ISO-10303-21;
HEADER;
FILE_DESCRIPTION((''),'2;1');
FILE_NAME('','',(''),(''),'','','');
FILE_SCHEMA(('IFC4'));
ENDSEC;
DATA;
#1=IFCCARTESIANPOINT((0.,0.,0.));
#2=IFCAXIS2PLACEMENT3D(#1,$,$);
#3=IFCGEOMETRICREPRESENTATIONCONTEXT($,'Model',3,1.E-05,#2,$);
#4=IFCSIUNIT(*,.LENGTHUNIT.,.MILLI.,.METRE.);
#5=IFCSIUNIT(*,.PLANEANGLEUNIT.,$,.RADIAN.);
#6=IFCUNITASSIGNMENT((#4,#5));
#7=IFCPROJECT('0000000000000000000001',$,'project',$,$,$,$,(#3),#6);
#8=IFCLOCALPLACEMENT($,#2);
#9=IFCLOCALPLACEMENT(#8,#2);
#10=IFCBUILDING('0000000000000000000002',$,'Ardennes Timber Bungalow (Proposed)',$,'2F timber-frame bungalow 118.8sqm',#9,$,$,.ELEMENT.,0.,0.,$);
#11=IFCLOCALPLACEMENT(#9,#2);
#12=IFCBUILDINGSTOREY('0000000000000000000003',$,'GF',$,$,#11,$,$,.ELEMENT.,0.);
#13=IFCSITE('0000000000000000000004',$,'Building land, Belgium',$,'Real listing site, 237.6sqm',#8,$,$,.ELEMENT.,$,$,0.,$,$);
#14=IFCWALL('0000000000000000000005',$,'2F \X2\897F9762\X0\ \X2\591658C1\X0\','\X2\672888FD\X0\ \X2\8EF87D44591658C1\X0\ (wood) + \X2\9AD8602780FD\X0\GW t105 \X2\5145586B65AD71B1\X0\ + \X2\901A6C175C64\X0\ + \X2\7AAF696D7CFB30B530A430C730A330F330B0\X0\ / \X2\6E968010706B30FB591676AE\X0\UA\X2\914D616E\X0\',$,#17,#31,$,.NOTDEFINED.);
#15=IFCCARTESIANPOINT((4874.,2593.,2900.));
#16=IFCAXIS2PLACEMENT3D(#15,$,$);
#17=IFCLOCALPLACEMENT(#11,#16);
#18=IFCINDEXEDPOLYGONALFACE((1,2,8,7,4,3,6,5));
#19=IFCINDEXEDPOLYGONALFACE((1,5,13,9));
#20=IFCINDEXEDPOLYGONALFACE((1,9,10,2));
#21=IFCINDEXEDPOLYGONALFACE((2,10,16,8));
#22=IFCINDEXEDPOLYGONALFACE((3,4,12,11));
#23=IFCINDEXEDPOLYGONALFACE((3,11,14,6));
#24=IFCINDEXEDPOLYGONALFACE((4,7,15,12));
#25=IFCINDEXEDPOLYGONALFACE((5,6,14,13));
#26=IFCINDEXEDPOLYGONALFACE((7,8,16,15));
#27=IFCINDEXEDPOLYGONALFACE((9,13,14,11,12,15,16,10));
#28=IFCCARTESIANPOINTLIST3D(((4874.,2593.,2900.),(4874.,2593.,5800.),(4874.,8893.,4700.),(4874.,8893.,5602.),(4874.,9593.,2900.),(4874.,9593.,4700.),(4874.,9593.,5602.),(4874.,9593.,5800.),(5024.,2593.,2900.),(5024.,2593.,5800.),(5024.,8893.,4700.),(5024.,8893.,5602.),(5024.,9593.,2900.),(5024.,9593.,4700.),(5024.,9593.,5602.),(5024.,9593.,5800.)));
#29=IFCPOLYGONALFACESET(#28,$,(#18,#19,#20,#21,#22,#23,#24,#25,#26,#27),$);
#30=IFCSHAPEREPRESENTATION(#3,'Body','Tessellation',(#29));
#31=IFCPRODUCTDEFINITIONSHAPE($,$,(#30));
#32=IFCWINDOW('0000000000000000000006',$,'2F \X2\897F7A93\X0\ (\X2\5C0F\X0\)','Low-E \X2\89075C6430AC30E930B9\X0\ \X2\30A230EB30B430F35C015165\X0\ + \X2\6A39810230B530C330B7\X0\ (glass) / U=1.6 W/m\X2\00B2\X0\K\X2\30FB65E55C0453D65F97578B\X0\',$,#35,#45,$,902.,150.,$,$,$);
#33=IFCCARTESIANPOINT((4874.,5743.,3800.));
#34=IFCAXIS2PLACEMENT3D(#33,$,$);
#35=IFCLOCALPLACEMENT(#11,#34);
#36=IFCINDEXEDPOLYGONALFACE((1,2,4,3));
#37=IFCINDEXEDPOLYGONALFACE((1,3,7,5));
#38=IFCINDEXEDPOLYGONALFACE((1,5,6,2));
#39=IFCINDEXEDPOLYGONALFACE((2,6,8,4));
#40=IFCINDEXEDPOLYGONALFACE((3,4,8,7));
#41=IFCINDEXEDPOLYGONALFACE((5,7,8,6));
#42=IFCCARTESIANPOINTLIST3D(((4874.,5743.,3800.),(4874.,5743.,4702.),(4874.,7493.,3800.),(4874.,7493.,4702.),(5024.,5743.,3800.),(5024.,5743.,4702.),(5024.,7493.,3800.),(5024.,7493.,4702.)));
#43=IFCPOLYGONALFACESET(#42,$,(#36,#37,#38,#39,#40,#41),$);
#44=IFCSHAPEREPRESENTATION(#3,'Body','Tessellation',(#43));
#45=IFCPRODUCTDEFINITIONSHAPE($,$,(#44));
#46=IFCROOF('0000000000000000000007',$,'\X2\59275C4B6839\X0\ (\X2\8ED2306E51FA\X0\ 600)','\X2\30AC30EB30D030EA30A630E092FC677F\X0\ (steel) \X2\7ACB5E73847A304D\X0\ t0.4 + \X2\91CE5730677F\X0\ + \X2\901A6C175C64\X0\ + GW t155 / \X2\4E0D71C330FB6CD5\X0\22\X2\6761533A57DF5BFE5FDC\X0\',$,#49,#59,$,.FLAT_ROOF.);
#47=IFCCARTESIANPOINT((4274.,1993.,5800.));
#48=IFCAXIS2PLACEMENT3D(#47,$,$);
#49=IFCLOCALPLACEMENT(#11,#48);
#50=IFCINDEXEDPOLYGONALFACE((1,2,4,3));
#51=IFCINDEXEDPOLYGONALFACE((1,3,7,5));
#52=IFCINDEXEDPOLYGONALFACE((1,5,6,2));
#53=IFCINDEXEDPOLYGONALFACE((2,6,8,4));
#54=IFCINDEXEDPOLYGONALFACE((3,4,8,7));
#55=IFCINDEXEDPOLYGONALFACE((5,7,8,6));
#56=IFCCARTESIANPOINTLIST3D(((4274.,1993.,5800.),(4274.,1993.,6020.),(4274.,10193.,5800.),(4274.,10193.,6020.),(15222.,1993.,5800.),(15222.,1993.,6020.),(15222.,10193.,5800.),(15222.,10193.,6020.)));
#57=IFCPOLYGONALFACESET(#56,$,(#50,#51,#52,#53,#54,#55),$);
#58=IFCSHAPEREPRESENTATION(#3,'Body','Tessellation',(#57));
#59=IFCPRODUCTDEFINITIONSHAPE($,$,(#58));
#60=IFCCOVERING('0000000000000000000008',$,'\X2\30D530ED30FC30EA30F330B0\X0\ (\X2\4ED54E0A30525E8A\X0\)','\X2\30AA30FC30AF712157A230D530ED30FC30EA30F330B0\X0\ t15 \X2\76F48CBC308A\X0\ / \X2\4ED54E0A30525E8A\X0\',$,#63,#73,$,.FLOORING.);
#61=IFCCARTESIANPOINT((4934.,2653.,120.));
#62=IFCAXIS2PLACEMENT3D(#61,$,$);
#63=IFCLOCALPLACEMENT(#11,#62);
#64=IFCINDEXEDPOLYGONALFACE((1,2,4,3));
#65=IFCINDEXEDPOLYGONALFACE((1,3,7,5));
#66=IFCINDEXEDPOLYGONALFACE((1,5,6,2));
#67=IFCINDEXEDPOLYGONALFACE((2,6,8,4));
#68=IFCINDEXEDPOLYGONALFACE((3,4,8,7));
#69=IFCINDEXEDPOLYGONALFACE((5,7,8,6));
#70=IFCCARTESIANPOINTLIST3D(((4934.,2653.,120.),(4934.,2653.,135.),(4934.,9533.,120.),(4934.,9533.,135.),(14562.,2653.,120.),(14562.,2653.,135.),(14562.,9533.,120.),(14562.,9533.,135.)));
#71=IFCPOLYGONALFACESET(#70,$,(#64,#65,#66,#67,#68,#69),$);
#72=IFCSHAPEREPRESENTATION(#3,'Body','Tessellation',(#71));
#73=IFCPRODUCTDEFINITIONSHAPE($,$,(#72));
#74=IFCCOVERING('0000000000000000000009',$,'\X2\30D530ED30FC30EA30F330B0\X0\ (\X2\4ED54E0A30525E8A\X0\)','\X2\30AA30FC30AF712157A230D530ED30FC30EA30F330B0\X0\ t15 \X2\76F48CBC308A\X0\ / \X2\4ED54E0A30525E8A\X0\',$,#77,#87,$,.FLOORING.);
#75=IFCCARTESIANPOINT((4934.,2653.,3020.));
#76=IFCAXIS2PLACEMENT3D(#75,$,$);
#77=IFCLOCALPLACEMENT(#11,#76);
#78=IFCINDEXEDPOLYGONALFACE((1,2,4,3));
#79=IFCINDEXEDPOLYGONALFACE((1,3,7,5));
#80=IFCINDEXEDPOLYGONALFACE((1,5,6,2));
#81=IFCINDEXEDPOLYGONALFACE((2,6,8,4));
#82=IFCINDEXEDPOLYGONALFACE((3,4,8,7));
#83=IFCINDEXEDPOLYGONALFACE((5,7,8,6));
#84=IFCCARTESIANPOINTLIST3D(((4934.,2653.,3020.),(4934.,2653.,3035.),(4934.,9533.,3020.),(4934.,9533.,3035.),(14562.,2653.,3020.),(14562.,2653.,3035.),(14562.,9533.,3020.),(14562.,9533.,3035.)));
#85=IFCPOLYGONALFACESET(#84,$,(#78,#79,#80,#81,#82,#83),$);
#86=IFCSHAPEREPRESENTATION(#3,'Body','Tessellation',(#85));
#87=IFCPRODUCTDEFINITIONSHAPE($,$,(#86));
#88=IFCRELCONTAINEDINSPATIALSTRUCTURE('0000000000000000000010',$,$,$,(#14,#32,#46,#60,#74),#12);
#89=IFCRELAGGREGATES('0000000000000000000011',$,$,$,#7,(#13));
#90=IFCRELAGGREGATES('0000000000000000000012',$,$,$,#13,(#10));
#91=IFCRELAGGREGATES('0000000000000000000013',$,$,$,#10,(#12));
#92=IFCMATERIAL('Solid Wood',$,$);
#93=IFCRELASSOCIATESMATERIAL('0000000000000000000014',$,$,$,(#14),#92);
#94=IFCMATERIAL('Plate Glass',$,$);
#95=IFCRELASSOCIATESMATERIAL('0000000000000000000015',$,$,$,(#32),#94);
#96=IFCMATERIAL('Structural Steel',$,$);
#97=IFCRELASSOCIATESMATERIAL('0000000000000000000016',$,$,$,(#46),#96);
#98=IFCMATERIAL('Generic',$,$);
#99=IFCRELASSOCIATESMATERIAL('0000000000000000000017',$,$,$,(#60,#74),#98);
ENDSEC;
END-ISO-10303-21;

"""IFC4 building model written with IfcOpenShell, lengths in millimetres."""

from ifc_helpers import new_model, si_unit, frame, frame_2d, origin, place, context, project, spatial, rectangle, extrude, material, element, fill, save


model = new_model("IFC4")

# Units and contexts
model_context = context("Model", 3, precision=1e-05, world=origin())
ifc_project = project(units=[si_unit("LENGTHUNIT", "METRE", prefix="MILLI"), si_unit("PLANEANGLEUNIT", "RADIAN")], contexts=[model_context])

# Site, building, storey
site_placement = place(None, origin())
site = spatial("IfcSite", under=ifc_project, at=site_placement, Name="Building land, Belgium", ObjectType="Real listing site, 237.6sqm", CompositionType="ELEMENT", RefElevation=0.0)
building_placement = place(site_placement, origin())
building = spatial("IfcBuilding", under=site, at=building_placement, Name="Ardennes Timber Bungalow (Proposed)", ObjectType="2F timber-frame bungalow 118.8sqm", CompositionType="ELEMENT", ElevationOfRefHeight=0.0, ElevationOfTerrain=0.0)
storey_placement = place(building_placement, origin())
storey = spatial("IfcBuildingStorey", under=building, at=storey_placement, Name="GF", CompositionType="ELEMENT", Elevation=0.0)

# Shared definitions
ifc_material_1 = material(Name="Solid Wood")

# Shared definitions
ifc_material_2 = material(Name="Plate Glass")

# Wall, opening, window
wall_1_placement = place(storey_placement, frame((4874.0, 2593.0, 2900.0)))
wall_1 = element("IfcWall", 1, at=wall_1_placement, inside=storey, material=ifc_material_1, Name="2F 西面 外壁", Description="木製 軸組外壁 (wood) + 高性能GW t105 充填断熱 + 通気層 + 窯業系サイディング / 準耐火・外皮UA配慮", PredefinedType="NOTDEFINED", context=model_context, shape_type="SweptSolid", body=[
    extrude(rectangle(XDim=150.0, YDim=7000.0, at=frame_2d((75.0, 3500.0))), frame((4874.0, 2593.0, 2900.0)), (0.0, 0.0, 1.0), 2900.0),
])
opening_1_placement = place(storey_placement, frame((4874.0, 5743.0, 3800.0)))
opening_1 = element("IfcOpeningElement", 2, at=opening_1_placement, cuts=wall_1, PredefinedType="NOTDEFINED", context=model_context, shape_type="SweptSolid", body=[
    extrude(rectangle(XDim=150.0, YDim=1750.0, at=frame_2d((75.0, 875.0))), frame((4874.0, 5743.0, 3800.0)), (0.0, 0.0, 1.0), 902.0),
])
window_1_placement = place(storey_placement, frame((4874.0, 5743.0, 3800.0)))
window_1 = element("IfcWindow", 3, at=window_1_placement, inside=storey, material=ifc_material_2, Name="2F 西窓 (小)", Description="Low-E 複層ガラス アルゴン封入 + 樹脂サッシ (glass) / U=1.6 W/m²K・日射取得型", OverallHeight=902.0, OverallWidth=150.0, context=model_context, shape_type="SweptSolid", body=[
    extrude(rectangle(XDim=150.0, YDim=1750.0, at=frame_2d((75.0, 875.0))), frame((4874.0, 5743.0, 3800.0)), (0.0, 0.0, 1.0), 902.0),
])
fill(opening_1, window_1)

# Roof
ifc_material_3 = material(Name="Structural Steel")
roof_placement = place(storey_placement, frame((4274.0, 1993.0, 5800.0)))
element("IfcRoof", 4, at=roof_placement, inside=storey, material=ifc_material_3, Name="大屋根 (軒の出 600)", Description="ガルバリウム鋼板 (steel) 立平葺き t0.4 + 野地板 + 通気層 + GW t155 / 不燃・法22条区域対応", PredefinedType="FLAT_ROOF", context=model_context, shape_type="SweptSolid", body=[
    extrude(rectangle(XDim=10948.0, YDim=8200.0, at=frame_2d((5474.0, 4100.0))), frame((4274.0, 1993.0, 5800.0)), (0.0, 0.0, 1.0), 220.0),
])

# Coverings
ifc_material_4 = material(Name="Generic")
covering_1_placement = place(storey_placement, frame((4934.0, 2653.0, 120.0)))
element("IfcCovering", 5, at=covering_1_placement, inside=storey, material=ifc_material_4, Name="フローリング (仕上げ床)", Description="オーク無垢フローリング t15 直貼り / 仕上げ床", PredefinedType="FLOORING", context=model_context, shape_type="SweptSolid", body=[
    extrude(rectangle(XDim=9628.0, YDim=6880.0, at=frame_2d((4814.0, 3440.0))), frame((4934.0, 2653.0, 120.0)), (0.0, 0.0, 1.0), 15.0),
])
covering_2_placement = place(storey_placement, frame((4934.0, 2653.0, 3020.0)))
element("IfcCovering", 6, at=covering_2_placement, inside=storey, material=ifc_material_4, Name="フローリング (仕上げ床)", Description="オーク無垢フローリング t15 直貼り / 仕上げ床", PredefinedType="FLOORING", context=model_context, shape_type="SweptSolid", body=[
    extrude(rectangle(XDim=9628.0, YDim=6880.0, at=frame_2d((4814.0, 3440.0))), frame((4934.0, 2653.0, 3020.0)), (0.0, 0.0, 1.0), 15.0),
])

save(model, "model.ifc")
